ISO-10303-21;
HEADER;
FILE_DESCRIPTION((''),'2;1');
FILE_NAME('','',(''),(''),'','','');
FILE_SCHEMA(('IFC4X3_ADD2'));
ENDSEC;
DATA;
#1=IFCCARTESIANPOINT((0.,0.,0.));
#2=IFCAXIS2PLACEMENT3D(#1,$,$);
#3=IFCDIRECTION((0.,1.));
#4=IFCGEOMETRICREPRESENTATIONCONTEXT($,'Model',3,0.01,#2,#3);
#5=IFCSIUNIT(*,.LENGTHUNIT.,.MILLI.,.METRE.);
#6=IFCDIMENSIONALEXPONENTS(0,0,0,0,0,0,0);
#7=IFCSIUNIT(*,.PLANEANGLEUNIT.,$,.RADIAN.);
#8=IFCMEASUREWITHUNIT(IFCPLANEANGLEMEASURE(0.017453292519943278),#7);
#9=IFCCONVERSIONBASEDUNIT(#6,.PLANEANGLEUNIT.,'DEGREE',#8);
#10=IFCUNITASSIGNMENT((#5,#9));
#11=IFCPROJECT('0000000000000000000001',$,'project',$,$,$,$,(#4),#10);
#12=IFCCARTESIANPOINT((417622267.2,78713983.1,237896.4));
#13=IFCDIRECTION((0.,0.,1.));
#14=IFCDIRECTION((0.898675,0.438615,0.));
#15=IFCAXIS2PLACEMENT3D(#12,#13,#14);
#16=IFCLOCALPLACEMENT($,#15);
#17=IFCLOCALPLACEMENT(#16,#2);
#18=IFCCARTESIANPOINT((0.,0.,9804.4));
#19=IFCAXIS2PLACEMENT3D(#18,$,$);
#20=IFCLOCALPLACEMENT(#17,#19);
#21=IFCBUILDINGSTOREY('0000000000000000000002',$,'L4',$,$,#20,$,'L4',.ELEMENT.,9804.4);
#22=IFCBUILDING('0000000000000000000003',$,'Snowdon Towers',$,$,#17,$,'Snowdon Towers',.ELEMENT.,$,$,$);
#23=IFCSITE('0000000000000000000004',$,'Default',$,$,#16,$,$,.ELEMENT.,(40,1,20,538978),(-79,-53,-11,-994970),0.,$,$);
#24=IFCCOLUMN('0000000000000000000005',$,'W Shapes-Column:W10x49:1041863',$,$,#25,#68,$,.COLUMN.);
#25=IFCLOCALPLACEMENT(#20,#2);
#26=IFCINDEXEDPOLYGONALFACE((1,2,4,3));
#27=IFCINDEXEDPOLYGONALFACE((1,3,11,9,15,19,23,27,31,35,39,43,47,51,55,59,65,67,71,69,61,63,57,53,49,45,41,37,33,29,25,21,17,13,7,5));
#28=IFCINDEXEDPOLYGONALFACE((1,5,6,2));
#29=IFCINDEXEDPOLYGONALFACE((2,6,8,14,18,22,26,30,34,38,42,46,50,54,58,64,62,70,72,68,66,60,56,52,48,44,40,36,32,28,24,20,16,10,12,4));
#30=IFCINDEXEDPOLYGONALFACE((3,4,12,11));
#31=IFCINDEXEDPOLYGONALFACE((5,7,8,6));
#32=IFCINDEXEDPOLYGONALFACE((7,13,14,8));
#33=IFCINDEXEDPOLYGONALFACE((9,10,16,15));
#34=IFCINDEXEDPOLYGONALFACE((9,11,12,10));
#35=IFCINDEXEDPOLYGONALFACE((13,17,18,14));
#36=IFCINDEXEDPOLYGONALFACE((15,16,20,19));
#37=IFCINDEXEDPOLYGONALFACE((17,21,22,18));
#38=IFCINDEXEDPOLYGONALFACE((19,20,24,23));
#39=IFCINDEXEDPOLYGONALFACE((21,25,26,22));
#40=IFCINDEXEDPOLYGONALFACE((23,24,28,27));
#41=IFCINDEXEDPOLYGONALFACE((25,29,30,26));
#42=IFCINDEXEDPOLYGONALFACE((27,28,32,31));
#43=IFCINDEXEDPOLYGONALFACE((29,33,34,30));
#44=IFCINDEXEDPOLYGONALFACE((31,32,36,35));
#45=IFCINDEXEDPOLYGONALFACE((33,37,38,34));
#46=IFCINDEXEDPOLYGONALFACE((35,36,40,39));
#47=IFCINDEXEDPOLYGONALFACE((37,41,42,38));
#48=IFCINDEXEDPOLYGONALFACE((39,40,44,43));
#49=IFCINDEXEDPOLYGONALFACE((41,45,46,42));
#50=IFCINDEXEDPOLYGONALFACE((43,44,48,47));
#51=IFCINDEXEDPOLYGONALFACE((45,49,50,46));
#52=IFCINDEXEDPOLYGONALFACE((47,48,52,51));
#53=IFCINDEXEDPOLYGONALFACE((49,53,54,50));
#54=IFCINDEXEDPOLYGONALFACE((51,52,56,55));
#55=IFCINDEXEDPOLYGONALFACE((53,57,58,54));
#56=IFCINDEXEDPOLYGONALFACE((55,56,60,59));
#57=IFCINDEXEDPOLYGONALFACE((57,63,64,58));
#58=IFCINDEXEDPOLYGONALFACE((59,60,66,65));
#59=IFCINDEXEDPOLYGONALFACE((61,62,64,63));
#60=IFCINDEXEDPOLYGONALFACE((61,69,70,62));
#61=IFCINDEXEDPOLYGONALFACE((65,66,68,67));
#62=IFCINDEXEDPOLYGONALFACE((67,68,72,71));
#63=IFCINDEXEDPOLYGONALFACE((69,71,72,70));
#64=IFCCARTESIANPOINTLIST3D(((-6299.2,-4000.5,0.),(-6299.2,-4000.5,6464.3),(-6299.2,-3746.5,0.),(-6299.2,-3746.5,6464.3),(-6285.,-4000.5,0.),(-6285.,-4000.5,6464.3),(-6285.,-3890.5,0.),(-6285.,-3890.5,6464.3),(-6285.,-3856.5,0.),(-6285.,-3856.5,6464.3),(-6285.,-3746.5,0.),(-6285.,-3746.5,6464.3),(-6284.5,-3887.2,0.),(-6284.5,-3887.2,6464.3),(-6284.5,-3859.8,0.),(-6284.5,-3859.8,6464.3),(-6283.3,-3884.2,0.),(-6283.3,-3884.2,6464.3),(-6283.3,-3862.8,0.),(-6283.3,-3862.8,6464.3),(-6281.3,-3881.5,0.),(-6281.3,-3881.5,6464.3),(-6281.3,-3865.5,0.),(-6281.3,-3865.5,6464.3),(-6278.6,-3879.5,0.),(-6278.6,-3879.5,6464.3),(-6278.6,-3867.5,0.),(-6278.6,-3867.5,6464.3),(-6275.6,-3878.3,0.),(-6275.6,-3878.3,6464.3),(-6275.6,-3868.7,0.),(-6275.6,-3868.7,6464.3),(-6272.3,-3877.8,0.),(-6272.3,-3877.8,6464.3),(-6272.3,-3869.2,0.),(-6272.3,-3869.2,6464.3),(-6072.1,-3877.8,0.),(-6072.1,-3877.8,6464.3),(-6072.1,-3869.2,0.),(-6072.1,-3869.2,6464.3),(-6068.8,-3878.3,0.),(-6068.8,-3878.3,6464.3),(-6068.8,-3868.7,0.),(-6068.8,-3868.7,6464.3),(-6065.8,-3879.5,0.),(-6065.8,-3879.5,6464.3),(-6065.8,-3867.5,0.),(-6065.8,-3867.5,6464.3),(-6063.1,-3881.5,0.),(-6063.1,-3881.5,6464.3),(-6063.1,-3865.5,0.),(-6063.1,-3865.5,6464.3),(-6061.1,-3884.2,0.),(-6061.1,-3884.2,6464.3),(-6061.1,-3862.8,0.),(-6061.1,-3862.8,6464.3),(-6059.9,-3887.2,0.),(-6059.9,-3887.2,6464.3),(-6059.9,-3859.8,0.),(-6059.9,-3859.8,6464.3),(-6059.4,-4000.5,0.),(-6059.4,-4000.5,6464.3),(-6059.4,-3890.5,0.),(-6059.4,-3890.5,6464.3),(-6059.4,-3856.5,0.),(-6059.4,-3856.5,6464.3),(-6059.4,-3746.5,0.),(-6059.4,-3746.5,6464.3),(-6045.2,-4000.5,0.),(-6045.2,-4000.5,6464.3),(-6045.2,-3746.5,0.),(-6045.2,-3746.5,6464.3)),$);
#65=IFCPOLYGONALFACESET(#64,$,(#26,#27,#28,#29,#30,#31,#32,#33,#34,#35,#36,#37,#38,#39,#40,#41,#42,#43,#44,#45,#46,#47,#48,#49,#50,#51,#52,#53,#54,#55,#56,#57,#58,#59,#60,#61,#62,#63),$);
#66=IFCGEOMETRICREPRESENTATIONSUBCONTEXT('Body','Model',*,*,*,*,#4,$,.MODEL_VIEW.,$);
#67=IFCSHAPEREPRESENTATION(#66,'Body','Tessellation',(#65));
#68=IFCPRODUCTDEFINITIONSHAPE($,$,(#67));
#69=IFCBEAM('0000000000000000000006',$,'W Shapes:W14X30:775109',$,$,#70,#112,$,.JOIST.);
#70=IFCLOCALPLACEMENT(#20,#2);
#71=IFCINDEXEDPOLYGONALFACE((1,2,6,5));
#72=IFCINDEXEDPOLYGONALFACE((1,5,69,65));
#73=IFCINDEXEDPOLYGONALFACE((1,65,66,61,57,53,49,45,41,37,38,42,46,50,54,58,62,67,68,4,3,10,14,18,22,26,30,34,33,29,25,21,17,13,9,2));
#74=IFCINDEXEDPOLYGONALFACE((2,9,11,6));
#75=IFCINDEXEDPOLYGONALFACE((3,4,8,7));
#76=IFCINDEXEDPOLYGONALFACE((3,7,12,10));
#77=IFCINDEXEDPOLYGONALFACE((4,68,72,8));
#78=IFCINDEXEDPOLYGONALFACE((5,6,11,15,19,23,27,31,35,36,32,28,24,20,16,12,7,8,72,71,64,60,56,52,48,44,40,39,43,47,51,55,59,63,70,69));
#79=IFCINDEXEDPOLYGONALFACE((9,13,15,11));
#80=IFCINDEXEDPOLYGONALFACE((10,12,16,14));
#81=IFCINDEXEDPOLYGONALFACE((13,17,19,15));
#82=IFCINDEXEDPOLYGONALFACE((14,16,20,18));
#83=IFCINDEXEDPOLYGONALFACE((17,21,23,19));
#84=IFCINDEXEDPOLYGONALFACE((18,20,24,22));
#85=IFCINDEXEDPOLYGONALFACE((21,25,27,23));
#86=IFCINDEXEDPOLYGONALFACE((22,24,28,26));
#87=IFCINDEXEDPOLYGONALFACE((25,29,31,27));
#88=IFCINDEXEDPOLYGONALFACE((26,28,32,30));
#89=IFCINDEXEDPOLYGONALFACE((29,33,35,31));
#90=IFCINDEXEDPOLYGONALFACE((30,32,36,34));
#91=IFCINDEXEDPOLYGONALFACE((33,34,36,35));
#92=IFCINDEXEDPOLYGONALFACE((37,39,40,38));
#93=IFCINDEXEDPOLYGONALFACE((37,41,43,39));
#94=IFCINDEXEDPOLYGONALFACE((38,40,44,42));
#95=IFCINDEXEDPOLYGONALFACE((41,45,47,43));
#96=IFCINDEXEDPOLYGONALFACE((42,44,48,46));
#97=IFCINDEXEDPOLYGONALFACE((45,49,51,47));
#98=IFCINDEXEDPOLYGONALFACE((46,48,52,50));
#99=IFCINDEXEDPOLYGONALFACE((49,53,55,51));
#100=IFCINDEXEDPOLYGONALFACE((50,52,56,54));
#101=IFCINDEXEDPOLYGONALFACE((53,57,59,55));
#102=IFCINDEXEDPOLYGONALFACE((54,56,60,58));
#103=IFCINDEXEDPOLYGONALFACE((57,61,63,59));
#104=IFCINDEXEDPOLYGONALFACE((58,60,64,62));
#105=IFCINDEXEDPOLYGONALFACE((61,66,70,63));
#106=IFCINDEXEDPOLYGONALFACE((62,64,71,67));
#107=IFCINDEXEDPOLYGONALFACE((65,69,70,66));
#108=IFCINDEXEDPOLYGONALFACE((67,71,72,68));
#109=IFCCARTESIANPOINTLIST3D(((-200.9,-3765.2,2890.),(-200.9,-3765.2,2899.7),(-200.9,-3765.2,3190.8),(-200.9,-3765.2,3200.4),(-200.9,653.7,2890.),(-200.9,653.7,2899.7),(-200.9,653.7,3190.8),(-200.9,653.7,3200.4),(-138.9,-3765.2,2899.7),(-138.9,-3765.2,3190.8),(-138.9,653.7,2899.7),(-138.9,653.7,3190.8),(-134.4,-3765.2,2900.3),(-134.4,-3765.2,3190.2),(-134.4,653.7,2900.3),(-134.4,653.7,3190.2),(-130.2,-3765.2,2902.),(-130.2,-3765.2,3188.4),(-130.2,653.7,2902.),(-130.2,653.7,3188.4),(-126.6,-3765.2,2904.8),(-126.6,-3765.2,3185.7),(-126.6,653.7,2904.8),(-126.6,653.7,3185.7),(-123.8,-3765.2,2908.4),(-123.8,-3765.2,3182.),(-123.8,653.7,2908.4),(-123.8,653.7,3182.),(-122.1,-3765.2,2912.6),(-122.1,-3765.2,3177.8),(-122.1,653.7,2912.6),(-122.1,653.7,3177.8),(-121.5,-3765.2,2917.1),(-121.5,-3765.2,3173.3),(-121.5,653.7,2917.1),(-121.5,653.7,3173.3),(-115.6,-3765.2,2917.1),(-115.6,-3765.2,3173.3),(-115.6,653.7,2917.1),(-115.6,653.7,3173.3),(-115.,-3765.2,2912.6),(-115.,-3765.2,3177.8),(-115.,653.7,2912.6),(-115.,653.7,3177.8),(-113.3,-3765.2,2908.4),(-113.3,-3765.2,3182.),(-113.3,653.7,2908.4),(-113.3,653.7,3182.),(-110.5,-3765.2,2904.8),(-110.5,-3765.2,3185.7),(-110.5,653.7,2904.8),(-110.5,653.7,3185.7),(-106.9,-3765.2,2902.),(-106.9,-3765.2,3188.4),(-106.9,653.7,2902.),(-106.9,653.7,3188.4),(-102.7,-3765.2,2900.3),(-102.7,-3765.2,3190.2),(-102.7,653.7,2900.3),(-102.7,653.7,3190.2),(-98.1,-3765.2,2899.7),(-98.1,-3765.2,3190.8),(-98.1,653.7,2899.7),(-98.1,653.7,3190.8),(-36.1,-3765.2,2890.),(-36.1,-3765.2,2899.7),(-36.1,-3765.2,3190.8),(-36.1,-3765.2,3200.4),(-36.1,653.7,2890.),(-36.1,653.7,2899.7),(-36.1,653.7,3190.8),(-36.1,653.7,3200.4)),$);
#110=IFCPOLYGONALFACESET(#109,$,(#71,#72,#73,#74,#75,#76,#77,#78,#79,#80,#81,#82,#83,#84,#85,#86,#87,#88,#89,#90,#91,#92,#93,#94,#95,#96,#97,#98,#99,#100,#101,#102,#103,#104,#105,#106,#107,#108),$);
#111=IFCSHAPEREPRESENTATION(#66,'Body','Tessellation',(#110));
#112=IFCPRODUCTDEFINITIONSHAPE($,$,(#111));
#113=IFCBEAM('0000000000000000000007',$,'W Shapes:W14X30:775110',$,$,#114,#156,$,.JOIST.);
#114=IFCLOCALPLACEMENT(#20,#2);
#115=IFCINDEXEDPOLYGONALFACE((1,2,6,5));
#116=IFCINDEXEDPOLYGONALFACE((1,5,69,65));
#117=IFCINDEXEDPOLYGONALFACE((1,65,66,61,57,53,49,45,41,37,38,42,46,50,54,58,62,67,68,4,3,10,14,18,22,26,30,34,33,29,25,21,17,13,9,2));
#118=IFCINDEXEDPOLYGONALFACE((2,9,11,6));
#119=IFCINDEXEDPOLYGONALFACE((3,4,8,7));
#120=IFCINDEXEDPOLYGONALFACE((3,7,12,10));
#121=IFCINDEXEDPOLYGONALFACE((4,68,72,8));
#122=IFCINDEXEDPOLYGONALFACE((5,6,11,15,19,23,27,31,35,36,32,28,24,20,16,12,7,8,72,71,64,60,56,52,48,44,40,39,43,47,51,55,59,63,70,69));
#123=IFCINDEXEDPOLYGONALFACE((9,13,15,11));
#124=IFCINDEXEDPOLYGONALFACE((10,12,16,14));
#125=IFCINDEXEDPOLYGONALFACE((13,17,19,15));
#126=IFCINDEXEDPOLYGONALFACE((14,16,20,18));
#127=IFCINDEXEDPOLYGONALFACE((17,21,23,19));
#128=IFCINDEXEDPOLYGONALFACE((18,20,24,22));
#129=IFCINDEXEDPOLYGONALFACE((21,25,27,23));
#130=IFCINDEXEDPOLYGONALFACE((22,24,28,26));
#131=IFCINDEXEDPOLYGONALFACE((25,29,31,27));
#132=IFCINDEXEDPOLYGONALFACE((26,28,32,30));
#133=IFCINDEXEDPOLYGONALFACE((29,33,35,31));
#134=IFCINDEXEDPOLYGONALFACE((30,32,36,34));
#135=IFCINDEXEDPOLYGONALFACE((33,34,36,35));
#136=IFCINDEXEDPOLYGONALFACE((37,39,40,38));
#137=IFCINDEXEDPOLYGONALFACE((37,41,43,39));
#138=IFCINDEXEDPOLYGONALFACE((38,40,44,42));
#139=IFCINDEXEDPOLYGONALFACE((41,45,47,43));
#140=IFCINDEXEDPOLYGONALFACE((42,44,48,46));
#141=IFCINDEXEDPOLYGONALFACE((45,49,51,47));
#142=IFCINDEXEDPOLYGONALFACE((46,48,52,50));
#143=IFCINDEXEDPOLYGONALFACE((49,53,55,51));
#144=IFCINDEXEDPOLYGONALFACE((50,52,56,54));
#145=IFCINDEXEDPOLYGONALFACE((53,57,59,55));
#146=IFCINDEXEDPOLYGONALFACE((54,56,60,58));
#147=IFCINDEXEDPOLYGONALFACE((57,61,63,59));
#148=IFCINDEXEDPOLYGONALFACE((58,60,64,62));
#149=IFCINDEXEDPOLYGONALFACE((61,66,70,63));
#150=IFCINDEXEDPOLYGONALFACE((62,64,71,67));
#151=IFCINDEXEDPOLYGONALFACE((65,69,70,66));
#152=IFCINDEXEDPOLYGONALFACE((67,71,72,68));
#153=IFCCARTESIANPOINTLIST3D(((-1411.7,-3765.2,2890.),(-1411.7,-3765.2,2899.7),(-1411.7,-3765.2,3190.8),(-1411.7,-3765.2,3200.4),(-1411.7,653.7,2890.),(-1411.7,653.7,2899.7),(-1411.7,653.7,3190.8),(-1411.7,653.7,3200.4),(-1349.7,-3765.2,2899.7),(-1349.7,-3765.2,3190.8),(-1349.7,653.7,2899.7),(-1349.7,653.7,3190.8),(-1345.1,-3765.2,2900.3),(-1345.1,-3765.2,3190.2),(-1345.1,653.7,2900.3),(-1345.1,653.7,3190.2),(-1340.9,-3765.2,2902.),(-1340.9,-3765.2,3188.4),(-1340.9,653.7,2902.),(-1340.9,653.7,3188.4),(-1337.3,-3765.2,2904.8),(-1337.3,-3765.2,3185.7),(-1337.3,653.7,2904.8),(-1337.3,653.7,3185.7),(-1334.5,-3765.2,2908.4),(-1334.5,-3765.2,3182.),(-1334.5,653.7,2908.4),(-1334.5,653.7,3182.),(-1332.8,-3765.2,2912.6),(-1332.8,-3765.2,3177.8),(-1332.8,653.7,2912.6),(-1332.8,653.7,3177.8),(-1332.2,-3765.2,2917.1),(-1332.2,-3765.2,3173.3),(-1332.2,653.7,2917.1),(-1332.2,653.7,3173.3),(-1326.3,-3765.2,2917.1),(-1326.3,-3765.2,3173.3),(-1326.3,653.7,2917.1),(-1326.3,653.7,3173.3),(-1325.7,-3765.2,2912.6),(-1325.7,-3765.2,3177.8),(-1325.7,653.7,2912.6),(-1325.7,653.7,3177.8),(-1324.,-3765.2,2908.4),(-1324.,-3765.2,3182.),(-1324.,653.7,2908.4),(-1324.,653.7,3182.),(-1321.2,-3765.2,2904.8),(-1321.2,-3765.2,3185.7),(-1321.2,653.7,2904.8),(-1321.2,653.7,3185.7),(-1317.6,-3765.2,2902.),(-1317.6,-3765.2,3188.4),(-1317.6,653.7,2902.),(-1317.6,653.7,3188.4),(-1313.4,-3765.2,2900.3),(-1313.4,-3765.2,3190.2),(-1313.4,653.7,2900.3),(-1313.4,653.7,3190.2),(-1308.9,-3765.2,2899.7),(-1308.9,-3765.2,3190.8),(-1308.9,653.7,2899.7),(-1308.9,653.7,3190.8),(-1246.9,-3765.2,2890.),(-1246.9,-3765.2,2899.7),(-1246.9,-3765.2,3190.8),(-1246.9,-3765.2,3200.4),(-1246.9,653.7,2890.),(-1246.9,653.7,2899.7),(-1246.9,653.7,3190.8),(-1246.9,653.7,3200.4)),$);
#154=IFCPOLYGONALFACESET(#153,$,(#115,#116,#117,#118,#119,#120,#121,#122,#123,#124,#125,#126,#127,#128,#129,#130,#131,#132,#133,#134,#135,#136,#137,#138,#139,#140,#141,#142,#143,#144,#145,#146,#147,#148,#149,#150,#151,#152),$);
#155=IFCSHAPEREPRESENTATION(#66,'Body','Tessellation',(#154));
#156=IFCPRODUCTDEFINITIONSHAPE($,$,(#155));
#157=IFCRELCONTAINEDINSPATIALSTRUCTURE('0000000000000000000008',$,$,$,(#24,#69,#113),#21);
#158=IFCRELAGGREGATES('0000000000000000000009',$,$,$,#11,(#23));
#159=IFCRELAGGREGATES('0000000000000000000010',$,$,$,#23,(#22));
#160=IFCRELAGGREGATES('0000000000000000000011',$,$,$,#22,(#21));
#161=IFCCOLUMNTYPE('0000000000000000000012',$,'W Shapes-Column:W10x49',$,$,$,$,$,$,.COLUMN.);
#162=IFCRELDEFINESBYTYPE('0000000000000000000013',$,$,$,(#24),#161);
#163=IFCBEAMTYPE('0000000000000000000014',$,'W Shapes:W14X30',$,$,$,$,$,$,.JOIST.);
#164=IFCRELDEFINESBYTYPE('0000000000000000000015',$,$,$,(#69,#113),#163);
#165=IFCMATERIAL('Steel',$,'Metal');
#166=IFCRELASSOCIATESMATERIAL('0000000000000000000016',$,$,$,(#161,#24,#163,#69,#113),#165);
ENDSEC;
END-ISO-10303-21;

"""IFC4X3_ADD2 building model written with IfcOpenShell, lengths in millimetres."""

from ifc_helpers import new_model, entity, si_unit, converted_unit, direction, frame, frame_2d, origin, place, context, subcontext, project, spatial, polyline, circle_curve, parameter, trimmed, segment, composite_curve, i_section, outline, extrude, source, transform, mapped, material, material_profile, profile_set, profile_usage, type_object, type_shapes, element, save


model = new_model("IFC4X3_ADD2")

# Units and contexts
model_context = context("Model", 3, precision=0.01, world=origin(), true_north=direction((0.0, 1.0)))
body_context = subcontext(model_context, "Body", "Model", "MODEL_VIEW")
ifc_project = project(units=[si_unit("LENGTHUNIT", "METRE", prefix="MILLI"), converted_unit("PLANEANGLEUNIT", "DEGREE", entity("IfcPlaneAngleMeasure", 0.017453292519943278), si_unit("PLANEANGLEUNIT", "RADIAN"), dimensions=[0, 0, 0, 0, 0, 0, 0])], contexts=[model_context])

# Site, building, storey
site_placement = place(None, frame((417622267.2, 78713983.1, 237896.4), z_axis=(0.0, 0.0, 1.0), x_axis=(0.898675, 0.438615, 0.0)))
site = spatial("IfcSite", under=ifc_project, at=site_placement, Name="Default", CompositionType="ELEMENT", RefLatitude=(40, 1, 20, 538978), RefLongitude=(-79, -53, -11, -994970), RefElevation=0.0)
building_placement = place(site_placement, origin())
building = spatial("IfcBuilding", under=site, at=building_placement, Name="Snowdon Towers", LongName="Snowdon Towers", CompositionType="ELEMENT")
storey_placement = place(building_placement, frame((0.0, 0.0, 9804.4)))
storey = spatial("IfcBuildingStorey", under=building, at=storey_placement, Name="L4", LongName="L4", CompositionType="ELEMENT", Elevation=9804.4)

# Column
ifc_material_1 = material(Name="Steel", Category="Metal")
ifc_material_profile_1 = material_profile(ifc_material_1, i_section(OverallWidth=254.0, OverallDepth=254.0, WebThickness=8.6, FlangeThickness=14.2, FilletRadius=12.7, at=frame_2d((0.0, 0.0), x_axis=(1.0, 0.0))), Name="W10x49")
ifc_profile_set_1 = profile_set([ifc_material_profile_1], Name="W10x49")
ifc_profile_usage_1 = profile_usage(ifc_profile_set_1)
column_type_1 = type_object("IfcColumnType", Name="W Shapes-Column:W10x49", PredefinedType="COLUMN", material=ifc_profile_set_1)
shared_shape_1 = source(origin(), body_context, "Body", "SweptSolid", [
    extrude(i_section(OverallWidth=254.0, OverallDepth=254.0, WebThickness=8.6, FlangeThickness=14.2, FilletRadius=12.7, at=frame_2d((0.0, 0.0), x_axis=(1.0, 0.0))), frame((0.0, 0.0, 9804.4), z_axis=(0.0, 0.0, 1.0), x_axis=(-1.0, 0.0, 0.0)), (0.0, 0.0, 1.0), 6464.3),
])
type_shapes(column_type_1, [shared_shape_1])
column_1_placement = place(storey_placement, frame((-6172.2, -3873.5, -9804.4), z_axis=(0.0, 0.0, 1.0), x_axis=(0.0, 1.0, 0.0)))
element("IfcColumn", 1, at=column_1_placement, inside=storey, type_object=column_type_1, material=ifc_profile_usage_1, Name="W Shapes-Column:W10x49:1041863", PredefinedType="COLUMN", context=body_context, shape_type="MappedRepresentation", body=[
    mapped(shared_shape_1, transform((0.0, 0.0, 0.0), scale=1.0)),
])

# Beams
ifc_material_profile_2 = material_profile(ifc_material_1, outline(composite_curve([segment(polyline([(-82.4, -145.6), (-82.4, -155.2)]), True, "CONTINUOUS"), segment(polyline([(-82.4, -155.2), (82.4, -155.2)]), True, "CONTINUOUS"), segment(polyline([(82.4, -155.2), (82.4, -145.6)]), True, "CONTINUOUS"), segment(polyline([(82.4, -145.6), (20.4, -145.6)]), True, "CONTINUOUS"), segment(trimmed(circle_curve(frame_2d((20.4, -128.1), x_axis=(1.0, 0.0)), 17.5), [parameter(180.0)], [parameter(270.0)], True, "PARAMETER"), False, "CONTINUOUS"), segment(polyline([(2.9, -128.1), (2.9, 128.1)]), True, "CONTINUOUS"), segment(trimmed(circle_curve(frame_2d((20.4, 128.1), x_axis=(1.0, 0.0)), 17.5), [parameter(90.0)], [parameter(180.0)], True, "PARAMETER"), False, "CONTINUOUS"), segment(polyline([(20.4, 145.6), (82.4, 145.6)]), True, "CONTINUOUS"), segment(polyline([(82.4, 145.6), (82.4, 155.2)]), True, "CONTINUOUS"), segment(polyline([(82.4, 155.2), (-82.4, 155.2)]), True, "CONTINUOUS"), segment(polyline([(-82.4, 155.2), (-82.4, 145.6)]), True, "CONTINUOUS"), segment(polyline([(-82.4, 145.6), (-20.4, 145.6)]), True, "CONTINUOUS"), segment(trimmed(circle_curve(frame_2d((-20.4, 128.1), x_axis=(1.0, 0.0)), 17.5), [parameter(360.0)], [parameter(90.0)], True, "PARAMETER"), False, "CONTINUOUS"), segment(polyline([(-2.9, 128.1), (-2.9, -128.1)]), True, "CONTINUOUS"), segment(trimmed(circle_curve(frame_2d((-20.4, -128.1), x_axis=(1.0, 0.0)), 17.5), [parameter(270.0)], [parameter(360.0)], True, "PARAMETER"), False, "CONTINUOUS"), segment(polyline([(-20.4, -145.6), (-82.4, -145.6)]), True, "CONTINUOUS")], self_intersect=False)), Name="W14X30")
ifc_profile_set_2 = profile_set([ifc_material_profile_2], Name="W14X30")
ifc_profile_usage_2 = profile_usage(ifc_profile_set_2, cardinal=8)
beam_type_1 = type_object("IfcBeamType", Name="W Shapes:W14X30", PredefinedType="JOIST", material=ifc_profile_set_2)
shared_shape_2 = source(origin(), body_context, "Body", "SweptSolid", [
    extrude(outline(composite_curve([segment(polyline([(-82.4, -145.6), (-82.4, -155.2)]), True, "CONTINUOUS"), segment(polyline([(-82.4, -155.2), (82.4, -155.2)]), True, "CONTINUOUS"), segment(polyline([(82.4, -155.2), (82.4, -145.6)]), True, "CONTINUOUS"), segment(polyline([(82.4, -145.6), (20.4, -145.6)]), True, "CONTINUOUS"), segment(trimmed(circle_curve(frame_2d((20.4, -128.1), x_axis=(1.0, 0.0)), 17.5), [parameter(180.0)], [parameter(270.0)], True, "PARAMETER"), False, "CONTINUOUS"), segment(polyline([(2.9, -128.1), (2.9, 128.1)]), True, "CONTINUOUS"), segment(trimmed(circle_curve(frame_2d((20.4, 128.1), x_axis=(1.0, 0.0)), 17.5), [parameter(90.0)], [parameter(180.0)], True, "PARAMETER"), False, "CONTINUOUS"), segment(polyline([(20.4, 145.6), (82.4, 145.6)]), True, "CONTINUOUS"), segment(polyline([(82.4, 145.6), (82.4, 155.2)]), True, "CONTINUOUS"), segment(polyline([(82.4, 155.2), (-82.4, 155.2)]), True, "CONTINUOUS"), segment(polyline([(-82.4, 155.2), (-82.4, 145.6)]), True, "CONTINUOUS"), segment(polyline([(-82.4, 145.6), (-20.4, 145.6)]), True, "CONTINUOUS"), segment(trimmed(circle_curve(frame_2d((-20.4, 128.1), x_axis=(1.0, 0.0)), 17.5), [parameter(360.0)], [parameter(90.0)], True, "PARAMETER"), False, "CONTINUOUS"), segment(polyline([(-2.9, 128.1), (-2.9, -128.1)]), True, "CONTINUOUS"), segment(trimmed(circle_curve(frame_2d((-20.4, -128.1), x_axis=(1.0, 0.0)), 17.5), [parameter(270.0)], [parameter(360.0)], True, "PARAMETER"), False, "CONTINUOUS"), segment(polyline([(-20.4, -145.6), (-82.4, -145.6)]), True, "CONTINUOUS")], self_intersect=False)), frame((-2209.4, 0.0, 0.0), z_axis=(-1.0, 0.0, 0.0), x_axis=(0.0, -1.0, 0.0)), (0.0, 0.0, -1.0), 4418.8),
])
type_shapes(beam_type_1, [shared_shape_2])
for number, where, z_axis, x_axis, name in (
    (2, (-118.5, -1555.8, 3045.2), (0.0, 0.0, 1.0), (0.0, -1.0, 0.0), "W Shapes:W14X30:775109"),
    (3, (-1329.3, -1555.8, 3045.2), (0.0, 0.0, 1.0), (0.0, -1.0, 0.0), "W Shapes:W14X30:775110"),
):
    element("IfcBeam", number, at=place(storey_placement, frame(where, z_axis=z_axis, x_axis=x_axis)), inside=storey, type_object=beam_type_1, material=ifc_profile_usage_2, Name=name, PredefinedType="JOIST", context=body_context, shape_type="MappedRepresentation", body=[
        mapped(shared_shape_2, transform((0.0, 0.0, 0.0), scale=1.0)),
    ])

save(model, "model.ifc")
